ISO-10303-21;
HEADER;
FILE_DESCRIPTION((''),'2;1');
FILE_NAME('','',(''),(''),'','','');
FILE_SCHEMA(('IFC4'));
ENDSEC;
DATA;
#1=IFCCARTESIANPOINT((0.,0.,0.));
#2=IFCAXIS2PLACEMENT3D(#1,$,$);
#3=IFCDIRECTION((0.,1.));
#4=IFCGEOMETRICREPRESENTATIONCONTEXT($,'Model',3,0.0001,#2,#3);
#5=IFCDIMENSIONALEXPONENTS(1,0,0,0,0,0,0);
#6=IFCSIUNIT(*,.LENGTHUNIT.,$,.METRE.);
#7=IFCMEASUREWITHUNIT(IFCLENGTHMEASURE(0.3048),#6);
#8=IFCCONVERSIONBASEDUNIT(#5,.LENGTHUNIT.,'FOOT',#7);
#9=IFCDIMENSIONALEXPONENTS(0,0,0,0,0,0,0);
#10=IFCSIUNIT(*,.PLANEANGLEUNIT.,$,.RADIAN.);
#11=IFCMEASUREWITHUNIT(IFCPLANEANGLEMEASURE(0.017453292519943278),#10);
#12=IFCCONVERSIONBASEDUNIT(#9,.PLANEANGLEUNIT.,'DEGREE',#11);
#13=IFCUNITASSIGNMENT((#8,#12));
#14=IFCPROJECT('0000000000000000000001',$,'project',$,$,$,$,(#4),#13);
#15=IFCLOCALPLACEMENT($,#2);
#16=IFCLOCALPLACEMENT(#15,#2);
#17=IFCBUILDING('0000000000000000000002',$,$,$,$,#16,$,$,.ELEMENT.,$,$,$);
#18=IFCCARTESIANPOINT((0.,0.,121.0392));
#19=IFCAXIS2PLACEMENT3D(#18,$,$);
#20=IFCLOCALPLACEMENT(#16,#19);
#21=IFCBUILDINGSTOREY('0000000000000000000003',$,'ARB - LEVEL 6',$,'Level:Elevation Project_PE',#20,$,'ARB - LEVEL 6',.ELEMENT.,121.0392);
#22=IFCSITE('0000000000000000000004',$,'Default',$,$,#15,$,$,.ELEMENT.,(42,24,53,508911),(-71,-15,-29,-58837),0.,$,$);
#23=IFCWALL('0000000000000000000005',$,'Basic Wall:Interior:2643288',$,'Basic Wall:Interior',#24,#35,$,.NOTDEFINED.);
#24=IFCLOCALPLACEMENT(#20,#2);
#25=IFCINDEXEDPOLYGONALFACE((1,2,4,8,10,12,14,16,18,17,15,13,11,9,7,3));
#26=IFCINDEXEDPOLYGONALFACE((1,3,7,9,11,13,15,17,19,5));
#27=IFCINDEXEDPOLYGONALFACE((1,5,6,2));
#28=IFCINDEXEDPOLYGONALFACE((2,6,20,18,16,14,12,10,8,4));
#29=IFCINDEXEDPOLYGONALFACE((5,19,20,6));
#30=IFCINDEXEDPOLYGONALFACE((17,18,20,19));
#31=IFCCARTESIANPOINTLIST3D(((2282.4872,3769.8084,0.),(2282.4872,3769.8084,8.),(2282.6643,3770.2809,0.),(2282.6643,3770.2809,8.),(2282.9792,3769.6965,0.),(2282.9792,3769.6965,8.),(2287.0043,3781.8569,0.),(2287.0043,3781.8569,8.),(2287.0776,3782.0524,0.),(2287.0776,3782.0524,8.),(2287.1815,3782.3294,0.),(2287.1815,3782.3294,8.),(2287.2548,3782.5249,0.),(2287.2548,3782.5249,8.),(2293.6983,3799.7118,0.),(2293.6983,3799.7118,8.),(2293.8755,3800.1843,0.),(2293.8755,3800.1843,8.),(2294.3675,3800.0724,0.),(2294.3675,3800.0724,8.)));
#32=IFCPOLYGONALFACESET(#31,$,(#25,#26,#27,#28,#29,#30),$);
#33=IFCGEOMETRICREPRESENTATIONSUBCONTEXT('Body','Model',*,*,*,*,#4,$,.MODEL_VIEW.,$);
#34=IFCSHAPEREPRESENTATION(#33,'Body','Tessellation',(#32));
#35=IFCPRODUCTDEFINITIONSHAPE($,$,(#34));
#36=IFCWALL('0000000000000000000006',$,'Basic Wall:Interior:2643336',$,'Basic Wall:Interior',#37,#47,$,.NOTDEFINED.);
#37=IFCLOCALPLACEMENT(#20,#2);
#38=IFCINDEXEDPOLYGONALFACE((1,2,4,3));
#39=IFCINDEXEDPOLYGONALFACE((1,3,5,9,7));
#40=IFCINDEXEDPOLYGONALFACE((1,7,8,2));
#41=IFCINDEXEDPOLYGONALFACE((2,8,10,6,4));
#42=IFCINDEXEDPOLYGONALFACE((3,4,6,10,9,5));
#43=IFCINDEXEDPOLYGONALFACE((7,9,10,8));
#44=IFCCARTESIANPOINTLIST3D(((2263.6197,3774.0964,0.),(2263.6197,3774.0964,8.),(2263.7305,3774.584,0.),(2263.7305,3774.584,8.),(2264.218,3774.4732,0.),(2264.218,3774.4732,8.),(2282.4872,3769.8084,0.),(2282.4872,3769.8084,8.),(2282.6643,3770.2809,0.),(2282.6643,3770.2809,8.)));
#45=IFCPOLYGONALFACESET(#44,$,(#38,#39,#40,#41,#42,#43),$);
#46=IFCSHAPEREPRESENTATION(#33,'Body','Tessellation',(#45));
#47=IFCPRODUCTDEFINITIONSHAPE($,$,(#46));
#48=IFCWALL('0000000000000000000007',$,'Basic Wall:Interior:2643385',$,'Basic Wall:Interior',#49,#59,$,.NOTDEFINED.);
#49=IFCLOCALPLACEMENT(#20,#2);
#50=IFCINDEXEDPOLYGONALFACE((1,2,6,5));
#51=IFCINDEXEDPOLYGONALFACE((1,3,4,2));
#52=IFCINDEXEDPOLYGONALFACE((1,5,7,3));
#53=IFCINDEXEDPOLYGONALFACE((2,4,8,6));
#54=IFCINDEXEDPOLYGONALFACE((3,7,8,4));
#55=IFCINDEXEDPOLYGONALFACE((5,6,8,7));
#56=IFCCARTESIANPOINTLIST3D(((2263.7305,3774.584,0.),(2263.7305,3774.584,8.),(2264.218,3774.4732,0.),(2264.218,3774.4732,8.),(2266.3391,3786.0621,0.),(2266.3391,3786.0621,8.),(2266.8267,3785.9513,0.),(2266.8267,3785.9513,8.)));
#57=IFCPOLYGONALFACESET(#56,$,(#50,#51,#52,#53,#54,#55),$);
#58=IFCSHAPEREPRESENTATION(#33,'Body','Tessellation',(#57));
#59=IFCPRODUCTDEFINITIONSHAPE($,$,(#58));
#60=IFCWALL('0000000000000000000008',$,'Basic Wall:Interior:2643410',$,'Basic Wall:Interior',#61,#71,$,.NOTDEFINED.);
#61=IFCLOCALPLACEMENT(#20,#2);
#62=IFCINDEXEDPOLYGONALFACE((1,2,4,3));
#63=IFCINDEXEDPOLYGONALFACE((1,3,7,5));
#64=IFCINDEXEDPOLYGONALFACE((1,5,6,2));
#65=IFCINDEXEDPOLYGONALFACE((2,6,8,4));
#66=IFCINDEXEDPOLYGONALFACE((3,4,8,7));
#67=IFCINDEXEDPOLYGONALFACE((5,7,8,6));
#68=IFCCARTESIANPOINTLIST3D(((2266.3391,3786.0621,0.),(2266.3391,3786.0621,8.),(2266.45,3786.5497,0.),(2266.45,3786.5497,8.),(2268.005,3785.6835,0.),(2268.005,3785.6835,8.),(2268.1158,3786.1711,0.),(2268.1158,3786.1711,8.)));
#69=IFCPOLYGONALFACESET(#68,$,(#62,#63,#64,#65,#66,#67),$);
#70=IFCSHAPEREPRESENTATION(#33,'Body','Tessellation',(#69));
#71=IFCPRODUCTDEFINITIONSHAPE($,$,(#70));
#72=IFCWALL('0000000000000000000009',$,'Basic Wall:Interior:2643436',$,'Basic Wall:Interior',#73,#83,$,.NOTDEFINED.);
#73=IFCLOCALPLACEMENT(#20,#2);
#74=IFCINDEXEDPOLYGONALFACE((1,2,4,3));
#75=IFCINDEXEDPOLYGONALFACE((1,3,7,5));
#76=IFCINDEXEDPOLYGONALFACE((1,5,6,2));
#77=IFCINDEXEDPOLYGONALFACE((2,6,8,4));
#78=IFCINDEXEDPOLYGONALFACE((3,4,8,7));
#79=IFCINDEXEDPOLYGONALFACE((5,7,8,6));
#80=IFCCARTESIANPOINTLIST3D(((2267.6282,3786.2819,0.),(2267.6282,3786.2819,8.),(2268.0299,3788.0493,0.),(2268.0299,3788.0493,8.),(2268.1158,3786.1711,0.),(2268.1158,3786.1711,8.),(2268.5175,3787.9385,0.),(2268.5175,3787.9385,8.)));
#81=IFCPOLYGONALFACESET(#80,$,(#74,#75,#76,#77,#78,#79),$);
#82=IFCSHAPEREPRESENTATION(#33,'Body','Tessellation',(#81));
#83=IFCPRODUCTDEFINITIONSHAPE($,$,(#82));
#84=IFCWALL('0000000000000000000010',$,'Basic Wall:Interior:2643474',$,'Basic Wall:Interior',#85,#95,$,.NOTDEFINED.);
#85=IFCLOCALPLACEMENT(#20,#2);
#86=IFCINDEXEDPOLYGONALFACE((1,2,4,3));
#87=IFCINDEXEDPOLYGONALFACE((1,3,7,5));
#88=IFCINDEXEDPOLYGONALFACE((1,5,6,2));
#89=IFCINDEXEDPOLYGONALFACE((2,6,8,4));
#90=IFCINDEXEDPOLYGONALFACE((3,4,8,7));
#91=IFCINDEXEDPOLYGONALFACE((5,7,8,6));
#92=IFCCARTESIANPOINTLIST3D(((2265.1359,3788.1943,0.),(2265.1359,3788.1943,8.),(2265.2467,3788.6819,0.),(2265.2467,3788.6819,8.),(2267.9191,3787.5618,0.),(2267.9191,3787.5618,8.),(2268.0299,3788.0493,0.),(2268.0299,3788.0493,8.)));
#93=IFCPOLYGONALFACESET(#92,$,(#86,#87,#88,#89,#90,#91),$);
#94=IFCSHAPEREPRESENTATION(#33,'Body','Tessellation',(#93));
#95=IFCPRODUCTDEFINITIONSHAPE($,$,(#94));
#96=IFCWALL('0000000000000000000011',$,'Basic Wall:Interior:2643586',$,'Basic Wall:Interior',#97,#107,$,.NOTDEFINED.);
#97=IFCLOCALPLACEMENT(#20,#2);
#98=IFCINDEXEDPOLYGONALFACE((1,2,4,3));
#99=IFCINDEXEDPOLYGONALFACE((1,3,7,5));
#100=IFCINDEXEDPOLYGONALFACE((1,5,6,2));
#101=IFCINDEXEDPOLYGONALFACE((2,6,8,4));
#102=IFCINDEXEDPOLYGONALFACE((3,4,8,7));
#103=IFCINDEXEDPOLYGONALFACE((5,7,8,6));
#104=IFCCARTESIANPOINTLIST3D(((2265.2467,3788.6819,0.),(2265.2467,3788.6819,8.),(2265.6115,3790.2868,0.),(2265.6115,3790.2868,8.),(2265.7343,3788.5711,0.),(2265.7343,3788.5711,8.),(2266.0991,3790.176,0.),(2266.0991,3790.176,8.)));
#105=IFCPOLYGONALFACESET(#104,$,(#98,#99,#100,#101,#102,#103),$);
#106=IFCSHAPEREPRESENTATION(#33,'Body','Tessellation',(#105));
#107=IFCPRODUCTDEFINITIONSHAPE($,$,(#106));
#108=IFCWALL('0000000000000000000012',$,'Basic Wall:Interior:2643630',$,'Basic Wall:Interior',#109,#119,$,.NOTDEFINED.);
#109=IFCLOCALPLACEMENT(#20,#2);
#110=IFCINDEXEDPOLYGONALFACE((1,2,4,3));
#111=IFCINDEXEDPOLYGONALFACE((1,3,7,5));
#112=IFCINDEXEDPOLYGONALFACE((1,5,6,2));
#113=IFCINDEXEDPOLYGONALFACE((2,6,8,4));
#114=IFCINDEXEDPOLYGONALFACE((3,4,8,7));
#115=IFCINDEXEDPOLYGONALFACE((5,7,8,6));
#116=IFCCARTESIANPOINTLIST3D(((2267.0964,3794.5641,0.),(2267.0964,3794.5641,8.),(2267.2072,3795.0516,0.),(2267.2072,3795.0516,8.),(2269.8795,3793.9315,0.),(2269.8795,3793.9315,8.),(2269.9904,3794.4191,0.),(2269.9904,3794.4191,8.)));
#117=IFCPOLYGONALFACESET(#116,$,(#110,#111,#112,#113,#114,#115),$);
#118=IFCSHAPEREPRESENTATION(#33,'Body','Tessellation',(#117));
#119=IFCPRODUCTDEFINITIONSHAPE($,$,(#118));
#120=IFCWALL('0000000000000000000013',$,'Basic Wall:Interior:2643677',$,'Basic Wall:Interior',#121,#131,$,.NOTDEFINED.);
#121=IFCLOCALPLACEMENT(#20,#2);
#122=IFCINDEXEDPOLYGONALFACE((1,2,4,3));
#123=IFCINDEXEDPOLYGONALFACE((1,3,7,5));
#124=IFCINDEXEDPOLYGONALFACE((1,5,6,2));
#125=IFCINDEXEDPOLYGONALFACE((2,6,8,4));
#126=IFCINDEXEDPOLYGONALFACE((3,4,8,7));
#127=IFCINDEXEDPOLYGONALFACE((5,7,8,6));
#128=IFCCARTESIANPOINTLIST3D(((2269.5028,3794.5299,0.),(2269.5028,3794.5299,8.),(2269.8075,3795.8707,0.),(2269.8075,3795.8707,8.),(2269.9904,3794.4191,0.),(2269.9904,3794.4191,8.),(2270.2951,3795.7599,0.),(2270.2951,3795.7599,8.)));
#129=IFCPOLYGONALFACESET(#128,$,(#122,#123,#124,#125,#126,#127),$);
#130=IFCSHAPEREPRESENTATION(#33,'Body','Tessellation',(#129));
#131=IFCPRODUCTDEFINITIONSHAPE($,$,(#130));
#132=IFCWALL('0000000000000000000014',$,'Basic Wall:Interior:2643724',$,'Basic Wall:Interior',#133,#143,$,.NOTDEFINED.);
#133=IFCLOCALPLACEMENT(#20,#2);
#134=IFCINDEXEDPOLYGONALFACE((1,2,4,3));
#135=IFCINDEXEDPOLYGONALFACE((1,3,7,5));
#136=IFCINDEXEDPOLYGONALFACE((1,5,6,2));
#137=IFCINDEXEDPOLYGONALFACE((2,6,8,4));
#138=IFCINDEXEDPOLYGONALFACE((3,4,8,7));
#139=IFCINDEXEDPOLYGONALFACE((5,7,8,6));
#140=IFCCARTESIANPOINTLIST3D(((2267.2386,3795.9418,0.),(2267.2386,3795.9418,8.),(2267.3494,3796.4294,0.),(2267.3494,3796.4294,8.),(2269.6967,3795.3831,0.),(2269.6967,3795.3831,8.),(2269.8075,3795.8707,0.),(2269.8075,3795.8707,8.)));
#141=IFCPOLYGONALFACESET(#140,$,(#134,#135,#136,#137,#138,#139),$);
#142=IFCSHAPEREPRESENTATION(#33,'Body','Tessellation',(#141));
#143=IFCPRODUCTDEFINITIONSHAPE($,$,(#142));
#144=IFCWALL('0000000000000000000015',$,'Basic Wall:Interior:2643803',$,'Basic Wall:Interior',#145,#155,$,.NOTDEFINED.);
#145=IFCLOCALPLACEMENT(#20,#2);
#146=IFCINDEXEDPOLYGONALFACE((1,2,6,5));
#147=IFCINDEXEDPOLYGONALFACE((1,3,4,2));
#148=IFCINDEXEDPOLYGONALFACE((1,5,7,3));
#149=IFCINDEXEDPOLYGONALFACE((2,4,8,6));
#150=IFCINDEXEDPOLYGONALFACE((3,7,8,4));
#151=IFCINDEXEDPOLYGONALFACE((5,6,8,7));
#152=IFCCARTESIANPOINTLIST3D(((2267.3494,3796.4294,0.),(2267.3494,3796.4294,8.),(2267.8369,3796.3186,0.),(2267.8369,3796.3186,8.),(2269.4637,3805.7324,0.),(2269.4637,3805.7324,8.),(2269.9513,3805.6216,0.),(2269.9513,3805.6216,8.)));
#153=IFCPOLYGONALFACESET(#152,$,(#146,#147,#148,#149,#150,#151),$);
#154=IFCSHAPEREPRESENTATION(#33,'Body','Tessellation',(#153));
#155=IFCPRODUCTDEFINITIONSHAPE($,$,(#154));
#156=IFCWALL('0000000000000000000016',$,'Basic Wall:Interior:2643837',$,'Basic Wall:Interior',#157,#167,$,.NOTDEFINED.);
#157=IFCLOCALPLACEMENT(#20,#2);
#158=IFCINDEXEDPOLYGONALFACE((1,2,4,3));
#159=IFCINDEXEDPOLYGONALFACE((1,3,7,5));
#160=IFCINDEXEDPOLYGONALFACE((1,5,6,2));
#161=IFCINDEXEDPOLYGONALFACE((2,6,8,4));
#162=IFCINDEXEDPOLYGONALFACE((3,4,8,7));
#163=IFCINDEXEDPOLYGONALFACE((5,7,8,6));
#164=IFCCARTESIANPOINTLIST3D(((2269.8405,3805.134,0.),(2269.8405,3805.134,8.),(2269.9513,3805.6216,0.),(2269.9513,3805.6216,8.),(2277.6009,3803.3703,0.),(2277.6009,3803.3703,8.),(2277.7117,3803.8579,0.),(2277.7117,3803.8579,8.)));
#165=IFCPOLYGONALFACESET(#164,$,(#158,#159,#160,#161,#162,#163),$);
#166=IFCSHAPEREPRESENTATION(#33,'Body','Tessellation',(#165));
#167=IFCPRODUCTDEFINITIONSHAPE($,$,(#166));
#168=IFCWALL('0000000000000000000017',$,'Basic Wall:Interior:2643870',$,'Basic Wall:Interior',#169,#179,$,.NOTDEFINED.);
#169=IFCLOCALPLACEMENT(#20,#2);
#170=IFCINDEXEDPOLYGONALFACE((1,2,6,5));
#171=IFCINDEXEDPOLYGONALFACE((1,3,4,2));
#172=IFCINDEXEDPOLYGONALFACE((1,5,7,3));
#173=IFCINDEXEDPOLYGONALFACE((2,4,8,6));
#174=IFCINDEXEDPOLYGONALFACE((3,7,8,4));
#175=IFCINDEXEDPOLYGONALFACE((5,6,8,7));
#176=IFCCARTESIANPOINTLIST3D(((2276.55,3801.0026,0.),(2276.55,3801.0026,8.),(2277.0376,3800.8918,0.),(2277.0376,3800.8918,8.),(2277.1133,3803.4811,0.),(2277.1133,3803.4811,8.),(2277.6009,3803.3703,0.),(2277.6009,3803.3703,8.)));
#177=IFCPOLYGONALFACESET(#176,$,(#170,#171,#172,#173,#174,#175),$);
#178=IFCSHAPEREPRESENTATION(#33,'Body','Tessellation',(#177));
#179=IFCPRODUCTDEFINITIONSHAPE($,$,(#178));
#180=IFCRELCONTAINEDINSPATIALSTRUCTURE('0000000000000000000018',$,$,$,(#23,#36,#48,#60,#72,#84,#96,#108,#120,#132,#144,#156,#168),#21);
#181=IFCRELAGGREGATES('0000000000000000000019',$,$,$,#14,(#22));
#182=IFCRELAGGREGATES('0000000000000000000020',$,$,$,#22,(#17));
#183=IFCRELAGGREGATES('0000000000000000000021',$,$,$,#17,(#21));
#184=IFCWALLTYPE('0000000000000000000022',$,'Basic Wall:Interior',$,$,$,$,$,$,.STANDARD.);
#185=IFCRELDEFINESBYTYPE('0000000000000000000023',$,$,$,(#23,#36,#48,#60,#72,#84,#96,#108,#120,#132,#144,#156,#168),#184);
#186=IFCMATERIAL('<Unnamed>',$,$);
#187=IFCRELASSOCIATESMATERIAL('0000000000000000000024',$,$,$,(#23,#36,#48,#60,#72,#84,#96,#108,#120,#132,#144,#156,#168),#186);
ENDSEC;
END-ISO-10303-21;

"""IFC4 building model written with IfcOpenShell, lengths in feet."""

from ifc_helpers import new_model, entity, si_unit, converted_unit, direction, frame, origin, place, context, subcontext, project, spatial, indexed_curve, outline, extrude, material, type_object, element, save


model = new_model("IFC4")

# Units and contexts
model_context = context("Model", 3, precision=0.0001, world=origin(), true_north=direction((0.0, 1.0)))
body_context = subcontext(model_context, "Body", "Model", "MODEL_VIEW")
ifc_project = project(units=[converted_unit("LENGTHUNIT", "FOOT", entity("IfcLengthMeasure", 0.3048), si_unit("LENGTHUNIT", "METRE"), dimensions=[1, 0, 0, 0, 0, 0, 0]), converted_unit("PLANEANGLEUNIT", "DEGREE", entity("IfcPlaneAngleMeasure", 0.017453292519943278), si_unit("PLANEANGLEUNIT", "RADIAN"), dimensions=[0, 0, 0, 0, 0, 0, 0])], contexts=[model_context])

# Site, building, storey
site_placement = place(None, origin())
site = spatial("IfcSite", under=ifc_project, at=site_placement, Name="Default", CompositionType="ELEMENT", RefLatitude=(42, 24, 53, 508911), RefLongitude=(-71, -15, -29, -58837), RefElevation=0.0)
building_placement = place(site_placement, origin())
building = spatial("IfcBuilding", under=site, at=building_placement, CompositionType="ELEMENT")
storey_placement = place(building_placement, frame((0.0, 0.0, 121.0392)))
storey = spatial("IfcBuildingStorey", under=building, at=storey_placement, Name="ARB - LEVEL 6", ObjectType="Level:Elevation Project_PE", LongName="ARB - LEVEL 6", CompositionType="ELEMENT", Elevation=121.0392)

# Walls
ifc_material = material(Name="<Unnamed>")
wall_type = type_object("IfcWallType", Name="Basic Wall:Interior", PredefinedType="STANDARD")
wall_1_placement = place(storey_placement, frame((2294.1335, 3800.1602, 0.0), z_axis=(0.0, 0.0, 1.0), x_axis=(-0.351052, -0.936356, 0.0)))
element("IfcWall", 1, at=wall_1_placement, inside=storey, type_object=wall_type, material=ifc_material, Name="Basic Wall:Interior:2643288", ObjectType="Basic Wall:Interior", PredefinedType="NOTDEFINED", context=body_context, shape_type="SweptSolid", body=[
    extrude(outline(indexed_curve([(32.5086, -0.25), (32.4405, 0.25), (0.0, 0.25), (0.068, -0.25), (0.5726, -0.25), (18.9277, -0.25), (19.1365, -0.25), (19.4323, -0.25), (19.6411, -0.25), (32.004, -0.25), (32.5086, -0.25)], self_intersect=False)), origin(), (0.0, 0.0, 1.0), 8.0),
])
wall_2_placement = place(storey_placement, frame((2282.6089, 3770.0371, 0.0), z_axis=(0.0, 0.0, 1.0), x_axis=(-0.975133, 0.221622, 0.0)))
element("IfcWall", 2, at=wall_2_placement, inside=storey, type_object=wall_type, material=ifc_material, Name="Basic Wall:Interior:2643336", ObjectType="Basic Wall:Interior", PredefinedType="NOTDEFINED", context=body_context, shape_type="SweptSolid", body=[
    extrude(outline(indexed_curve([(19.4167, -0.25), (19.4167, 0.25), (0.068, 0.25), (0.0, -0.25), (18.9167, -0.25), (19.4167, -0.25)], self_intersect=False)), origin(), (0.0, 0.0, 1.0), 8.0),
])
wall_3_placement = place(storey_placement, frame((2263.9743, 3774.5286, 0.0), z_axis=(0.0, 0.0, 1.0), x_axis=(0.221622, 0.975133, 0.0)))
element("IfcWall", 3, at=wall_3_placement, inside=storey, type_object=wall_type, material=ifc_material, Name="Basic Wall:Interior:2643385", ObjectType="Basic Wall:Interior", PredefinedType="NOTDEFINED", context=body_context, shape_type="SweptSolid", body=[
    extrude(outline(indexed_curve([(11.7708, 0.25), (0.0, 0.25), (0.0, -0.25), (11.7708, -0.25), (11.7708, 0.25)], self_intersect=False)), origin(), (0.0, 0.0, 1.0), 8.0),
])
wall_4_placement = place(storey_placement, frame((2266.3946, 3786.3059, 0.0), z_axis=(0.0, 0.0, 1.0), x_axis=(0.975133, -0.221622, 0.0)))
element("IfcWall", 4, at=wall_4_placement, inside=storey, type_object=wall_type, material=ifc_material, Name="Basic Wall:Interior:2643410", ObjectType="Basic Wall:Interior", PredefinedType="NOTDEFINED", context=body_context, shape_type="SweptSolid", body=[
    extrude(outline(indexed_curve([(1.7083, 0.25), (0.0, 0.25), (0.0, -0.25), (1.7083, -0.25), (1.7083, 0.25)], self_intersect=False)), origin(), (0.0, 0.0, 1.0), 8.0),
])
wall_5_placement = place(storey_placement, frame((2267.872, 3786.2265, 0.0), z_axis=(0.0, 0.0, 1.0), x_axis=(0.221622, 0.975133, 0.0)))
element("IfcWall", 5, at=wall_5_placement, inside=storey, type_object=wall_type, material=ifc_material, Name="Basic Wall:Interior:2643436", ObjectType="Basic Wall:Interior", PredefinedType="NOTDEFINED", context=body_context, shape_type="SweptSolid", body=[
    extrude(outline(indexed_curve([(1.8125, 0.25), (0.0, 0.25), (0.0, -0.25), (1.8125, -0.25), (1.8125, 0.25)], self_intersect=False)), origin(), (0.0, 0.0, 1.0), 8.0),
])
wall_6_placement = place(storey_placement, frame((2267.9745, 3787.8056, 0.0), z_axis=(0.0, 0.0, 1.0), x_axis=(-0.975133, 0.221622, 0.0)))
element("IfcWall", 6, at=wall_6_placement, inside=storey, type_object=wall_type, material=ifc_material, Name="Basic Wall:Interior:2643474", ObjectType="Basic Wall:Interior", PredefinedType="NOTDEFINED", context=body_context, shape_type="SweptSolid", body=[
    extrude(outline(indexed_curve([(2.8542, 0.25), (0.0, 0.25), (0.0, -0.25), (2.8542, -0.25), (2.8542, 0.25)], self_intersect=False)), origin(), (0.0, 0.0, 1.0), 8.0),
])
wall_7_placement = place(storey_placement, frame((2265.4905, 3788.6265, 0.0), z_axis=(0.0, 0.0, 1.0), x_axis=(0.221622, 0.975133, 0.0)))
element("IfcWall", 7, at=wall_7_placement, inside=storey, type_object=wall_type, material=ifc_material, Name="Basic Wall:Interior:2643586", ObjectType="Basic Wall:Interior", PredefinedType="NOTDEFINED", context=body_context, shape_type="SweptSolid", body=[
    extrude(outline(indexed_curve([(1.6458, 0.25), (0.0, 0.25), (0.0, -0.25), (1.6458, -0.25), (1.6458, 0.25)], self_intersect=False)), origin(), (0.0, 0.0, 1.0), 8.0),
])
wall_8_placement = place(storey_placement, frame((2267.1518, 3794.8079, 0.0), z_axis=(0.0, 0.0, 1.0), x_axis=(0.975133, -0.221622, 0.0)))
element("IfcWall", 8, at=wall_8_placement, inside=storey, type_object=wall_type, material=ifc_material, Name="Basic Wall:Interior:2643630", ObjectType="Basic Wall:Interior", PredefinedType="NOTDEFINED", context=body_context, shape_type="SweptSolid", body=[
    extrude(outline(indexed_curve([(2.8542, 0.25), (0.0, 0.25), (0.0, -0.25), (2.8542, -0.25), (2.8542, 0.25)], self_intersect=False)), origin(), (0.0, 0.0, 1.0), 8.0),
])
wall_9_placement = place(storey_placement, frame((2269.7466, 3794.4745, 0.0), z_axis=(0.0, 0.0, 1.0), x_axis=(0.221622, 0.975133, 0.0)))
element("IfcWall", 9, at=wall_9_placement, inside=storey, type_object=wall_type, material=ifc_material, Name="Basic Wall:Interior:2643677", ObjectType="Basic Wall:Interior", PredefinedType="NOTDEFINED", context=body_context, shape_type="SweptSolid", body=[
    extrude(outline(indexed_curve([(1.375, 0.25), (0.0, 0.25), (0.0, -0.25), (1.375, -0.25), (1.375, 0.25)], self_intersect=False)), origin(), (0.0, 0.0, 1.0), 8.0),
])
wall_10_placement = place(storey_placement, frame((2269.7521, 3795.6269, 0.0), z_axis=(0.0, 0.0, 1.0), x_axis=(-0.975133, 0.221622, 0.0)))
element("IfcWall", 10, at=wall_10_placement, inside=storey, type_object=wall_type, material=ifc_material, Name="Basic Wall:Interior:2643724", ObjectType="Basic Wall:Interior", PredefinedType="NOTDEFINED", context=body_context, shape_type="SweptSolid", body=[
    extrude(outline(indexed_curve([(2.5208, 0.25), (0.0, 0.25), (0.0, -0.25), (2.5208, -0.25), (2.5208, 0.25)], self_intersect=False)), origin(), (0.0, 0.0, 1.0), 8.0),
])
wall_11_placement = place(storey_placement, frame((2267.5932, 3796.374, 0.0), z_axis=(0.0, 0.0, 1.0), x_axis=(0.221622, 0.975133, 0.0)))
element("IfcWall", 11, at=wall_11_placement, inside=storey, type_object=wall_type, material=ifc_material, Name="Basic Wall:Interior:2643803", ObjectType="Basic Wall:Interior", PredefinedType="NOTDEFINED", context=body_context, shape_type="SweptSolid", body=[
    extrude(outline(indexed_curve([(9.5403, 0.25), (0.0, 0.25), (0.0, -0.25), (9.5403, -0.25), (9.5403, 0.25)], self_intersect=False)), origin(), (0.0, 0.0, 1.0), 8.0),
])
wall_12_placement = place(storey_placement, frame((2269.8959, 3805.3778, 0.0), z_axis=(0.0, 0.0, 1.0), x_axis=(0.975133, -0.221622, 0.0)))
element("IfcWall", 12, at=wall_12_placement, inside=storey, type_object=wall_type, material=ifc_material, Name="Basic Wall:Interior:2643837", ObjectType="Basic Wall:Interior", PredefinedType="NOTDEFINED", context=body_context, shape_type="SweptSolid", body=[
    extrude(outline(indexed_curve([(7.9583, 0.25), (0.0, 0.25), (0.0, -0.25), (7.9583, -0.25), (7.9583, 0.25)], self_intersect=False)), origin(), (0.0, 0.0, 1.0), 8.0),
])
wall_13_placement = place(storey_placement, frame((2277.3571, 3803.4257, 0.0), z_axis=(0.0, 0.0, 1.0), x_axis=(-0.221622, -0.975133, 0.0)))
element("IfcWall", 13, at=wall_13_placement, inside=storey, type_object=wall_type, material=ifc_material, Name="Basic Wall:Interior:2643870", ObjectType="Basic Wall:Interior", PredefinedType="NOTDEFINED", context=body_context, shape_type="SweptSolid", body=[
    extrude(outline(indexed_curve([(2.5417, 0.25), (0.0, 0.25), (0.0, -0.25), (2.5417, -0.25), (2.5417, 0.25)], self_intersect=False)), origin(), (0.0, 0.0, 1.0), 8.0),
])

save(model, "model.ifc")
